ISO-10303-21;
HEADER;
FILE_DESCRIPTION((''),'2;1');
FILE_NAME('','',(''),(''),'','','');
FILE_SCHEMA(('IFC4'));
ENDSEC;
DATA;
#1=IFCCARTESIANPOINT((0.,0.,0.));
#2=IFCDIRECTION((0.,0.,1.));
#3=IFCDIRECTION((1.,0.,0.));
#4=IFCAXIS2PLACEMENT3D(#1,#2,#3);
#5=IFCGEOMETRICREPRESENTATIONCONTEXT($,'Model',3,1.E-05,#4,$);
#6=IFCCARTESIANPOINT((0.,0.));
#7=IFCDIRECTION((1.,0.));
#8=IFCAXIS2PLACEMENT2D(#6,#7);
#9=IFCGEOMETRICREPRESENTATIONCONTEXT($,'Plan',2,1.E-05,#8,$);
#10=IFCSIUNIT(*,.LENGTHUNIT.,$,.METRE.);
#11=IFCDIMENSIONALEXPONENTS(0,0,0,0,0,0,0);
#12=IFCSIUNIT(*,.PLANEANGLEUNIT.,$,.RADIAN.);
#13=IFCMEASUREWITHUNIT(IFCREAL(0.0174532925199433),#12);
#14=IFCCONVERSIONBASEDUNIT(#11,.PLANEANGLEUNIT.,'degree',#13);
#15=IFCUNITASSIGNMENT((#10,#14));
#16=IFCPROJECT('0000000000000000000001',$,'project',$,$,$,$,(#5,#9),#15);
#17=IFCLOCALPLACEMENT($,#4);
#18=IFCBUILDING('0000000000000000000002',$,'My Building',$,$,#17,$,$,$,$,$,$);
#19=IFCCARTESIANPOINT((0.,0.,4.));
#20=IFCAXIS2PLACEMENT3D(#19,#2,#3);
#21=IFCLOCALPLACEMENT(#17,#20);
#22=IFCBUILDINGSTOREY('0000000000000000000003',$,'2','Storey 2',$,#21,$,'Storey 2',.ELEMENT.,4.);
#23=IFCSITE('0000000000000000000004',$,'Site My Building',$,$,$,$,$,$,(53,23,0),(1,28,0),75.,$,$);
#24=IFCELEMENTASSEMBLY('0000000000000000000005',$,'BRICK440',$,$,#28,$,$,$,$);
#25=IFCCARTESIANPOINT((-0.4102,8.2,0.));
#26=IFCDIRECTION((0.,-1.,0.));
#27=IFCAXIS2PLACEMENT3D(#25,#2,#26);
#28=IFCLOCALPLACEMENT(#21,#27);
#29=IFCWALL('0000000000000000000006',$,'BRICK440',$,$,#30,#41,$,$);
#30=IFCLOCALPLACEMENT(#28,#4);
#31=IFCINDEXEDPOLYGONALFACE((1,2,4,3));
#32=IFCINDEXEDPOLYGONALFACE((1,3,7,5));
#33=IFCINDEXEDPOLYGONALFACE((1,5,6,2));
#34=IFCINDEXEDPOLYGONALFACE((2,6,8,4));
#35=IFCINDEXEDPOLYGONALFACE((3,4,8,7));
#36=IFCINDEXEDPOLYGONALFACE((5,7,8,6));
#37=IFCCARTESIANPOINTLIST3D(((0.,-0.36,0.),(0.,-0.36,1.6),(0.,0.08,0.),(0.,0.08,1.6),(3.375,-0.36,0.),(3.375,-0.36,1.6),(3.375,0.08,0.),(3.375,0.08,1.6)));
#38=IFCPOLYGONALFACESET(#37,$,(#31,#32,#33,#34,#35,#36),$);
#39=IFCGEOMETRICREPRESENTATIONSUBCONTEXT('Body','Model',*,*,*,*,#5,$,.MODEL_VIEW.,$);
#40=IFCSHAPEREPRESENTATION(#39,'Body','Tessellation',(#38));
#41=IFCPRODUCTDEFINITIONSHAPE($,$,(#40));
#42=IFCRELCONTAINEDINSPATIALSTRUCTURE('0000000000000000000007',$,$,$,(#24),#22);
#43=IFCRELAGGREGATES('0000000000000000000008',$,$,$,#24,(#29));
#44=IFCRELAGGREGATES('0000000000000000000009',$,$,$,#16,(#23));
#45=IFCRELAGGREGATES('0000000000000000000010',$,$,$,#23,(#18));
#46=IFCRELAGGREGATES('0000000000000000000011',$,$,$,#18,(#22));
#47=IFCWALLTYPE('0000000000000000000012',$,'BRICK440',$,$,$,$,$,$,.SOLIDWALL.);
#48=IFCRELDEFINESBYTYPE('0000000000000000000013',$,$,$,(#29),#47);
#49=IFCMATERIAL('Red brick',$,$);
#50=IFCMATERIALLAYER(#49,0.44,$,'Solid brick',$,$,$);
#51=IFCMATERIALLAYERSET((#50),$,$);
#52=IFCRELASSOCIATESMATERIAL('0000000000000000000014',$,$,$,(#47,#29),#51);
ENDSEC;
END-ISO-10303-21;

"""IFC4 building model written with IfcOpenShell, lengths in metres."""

from ifc_helpers import new_model, entity, si_unit, converted_unit, frame, origin, origin_with_axes, origin_2d_with_axis, place, context, subcontext, project, spatial, polyline, outline, extrude, material, layer, layer_set, layer_usage, type_object, element, aggregate, save


model = new_model("IFC4")

# Units and contexts
model_context = context("Model", 3, precision=1e-05, world=origin_with_axes())
plan_context = context("Plan", 2, precision=1e-05, world=origin_2d_with_axis())
body_context = subcontext(model_context, "Body", "Model", "MODEL_VIEW")
ifc_project = project(units=[si_unit("LENGTHUNIT", "METRE"), converted_unit("PLANEANGLEUNIT", "degree", entity("IfcReal", 0.0174532925199433), si_unit("PLANEANGLEUNIT", "RADIAN"), dimensions=[0, 0, 0, 0, 0, 0, 0])], contexts=[model_context, plan_context])

# Site, building, storey
site = spatial("IfcSite", under=ifc_project, Name="Site My Building", RefLatitude=(53, 23, 0), RefLongitude=(1, 28, 0), RefElevation=75.0)
building_placement = place(None, origin_with_axes())
building = spatial("IfcBuilding", under=site, at=building_placement, Name="My Building")
storey_placement = place(building_placement, frame((0.0, 0.0, 4.0), z_axis=(0.0, 0.0, 1.0), x_axis=(1.0, 0.0, 0.0)))
storey = spatial("IfcBuildingStorey", under=building, at=storey_placement, Name="2", Description="Storey 2", LongName="Storey 2", CompositionType="ELEMENT", Elevation=4.0)

# Element assembly, wall
assembly_placement = place(storey_placement, frame((-0.4102, 8.2, 0.0), z_axis=(0.0, 0.0, 1.0), x_axis=(0.0, -1.0, 0.0)))
assembly = element("IfcElementAssembly", 1, at=assembly_placement, inside=storey, Name="BRICK440")
ifc_material = material(Name="Red brick")
ifc_layer = layer(ifc_material, 0.44, Name="Solid brick")
ifc_layer_set = layer_set([ifc_layer])
ifc_layer_usage = layer_usage(ifc_layer_set, "AXIS2", "POSITIVE", -0.36)
wall_type = type_object("IfcWallType", Name="BRICK440", PredefinedType="SOLIDWALL", material=ifc_layer_set)
wall_placement = place(assembly_placement, origin_with_axes())
wall = element("IfcWall", 2, at=wall_placement, type_object=wall_type, material=ifc_layer_usage, Name="BRICK440", context=body_context, shape_type="SweptSolid", body=[
    extrude(outline(polyline([(0.0, 0.08), (0.0, -0.36), (3.375, -0.36), (3.375, 0.08), (0.0, 0.08)])), origin(), (0.0, 0.0, 1.0), 1.6),
])
aggregate(assembly, [wall])

save(model, "model.ifc")
